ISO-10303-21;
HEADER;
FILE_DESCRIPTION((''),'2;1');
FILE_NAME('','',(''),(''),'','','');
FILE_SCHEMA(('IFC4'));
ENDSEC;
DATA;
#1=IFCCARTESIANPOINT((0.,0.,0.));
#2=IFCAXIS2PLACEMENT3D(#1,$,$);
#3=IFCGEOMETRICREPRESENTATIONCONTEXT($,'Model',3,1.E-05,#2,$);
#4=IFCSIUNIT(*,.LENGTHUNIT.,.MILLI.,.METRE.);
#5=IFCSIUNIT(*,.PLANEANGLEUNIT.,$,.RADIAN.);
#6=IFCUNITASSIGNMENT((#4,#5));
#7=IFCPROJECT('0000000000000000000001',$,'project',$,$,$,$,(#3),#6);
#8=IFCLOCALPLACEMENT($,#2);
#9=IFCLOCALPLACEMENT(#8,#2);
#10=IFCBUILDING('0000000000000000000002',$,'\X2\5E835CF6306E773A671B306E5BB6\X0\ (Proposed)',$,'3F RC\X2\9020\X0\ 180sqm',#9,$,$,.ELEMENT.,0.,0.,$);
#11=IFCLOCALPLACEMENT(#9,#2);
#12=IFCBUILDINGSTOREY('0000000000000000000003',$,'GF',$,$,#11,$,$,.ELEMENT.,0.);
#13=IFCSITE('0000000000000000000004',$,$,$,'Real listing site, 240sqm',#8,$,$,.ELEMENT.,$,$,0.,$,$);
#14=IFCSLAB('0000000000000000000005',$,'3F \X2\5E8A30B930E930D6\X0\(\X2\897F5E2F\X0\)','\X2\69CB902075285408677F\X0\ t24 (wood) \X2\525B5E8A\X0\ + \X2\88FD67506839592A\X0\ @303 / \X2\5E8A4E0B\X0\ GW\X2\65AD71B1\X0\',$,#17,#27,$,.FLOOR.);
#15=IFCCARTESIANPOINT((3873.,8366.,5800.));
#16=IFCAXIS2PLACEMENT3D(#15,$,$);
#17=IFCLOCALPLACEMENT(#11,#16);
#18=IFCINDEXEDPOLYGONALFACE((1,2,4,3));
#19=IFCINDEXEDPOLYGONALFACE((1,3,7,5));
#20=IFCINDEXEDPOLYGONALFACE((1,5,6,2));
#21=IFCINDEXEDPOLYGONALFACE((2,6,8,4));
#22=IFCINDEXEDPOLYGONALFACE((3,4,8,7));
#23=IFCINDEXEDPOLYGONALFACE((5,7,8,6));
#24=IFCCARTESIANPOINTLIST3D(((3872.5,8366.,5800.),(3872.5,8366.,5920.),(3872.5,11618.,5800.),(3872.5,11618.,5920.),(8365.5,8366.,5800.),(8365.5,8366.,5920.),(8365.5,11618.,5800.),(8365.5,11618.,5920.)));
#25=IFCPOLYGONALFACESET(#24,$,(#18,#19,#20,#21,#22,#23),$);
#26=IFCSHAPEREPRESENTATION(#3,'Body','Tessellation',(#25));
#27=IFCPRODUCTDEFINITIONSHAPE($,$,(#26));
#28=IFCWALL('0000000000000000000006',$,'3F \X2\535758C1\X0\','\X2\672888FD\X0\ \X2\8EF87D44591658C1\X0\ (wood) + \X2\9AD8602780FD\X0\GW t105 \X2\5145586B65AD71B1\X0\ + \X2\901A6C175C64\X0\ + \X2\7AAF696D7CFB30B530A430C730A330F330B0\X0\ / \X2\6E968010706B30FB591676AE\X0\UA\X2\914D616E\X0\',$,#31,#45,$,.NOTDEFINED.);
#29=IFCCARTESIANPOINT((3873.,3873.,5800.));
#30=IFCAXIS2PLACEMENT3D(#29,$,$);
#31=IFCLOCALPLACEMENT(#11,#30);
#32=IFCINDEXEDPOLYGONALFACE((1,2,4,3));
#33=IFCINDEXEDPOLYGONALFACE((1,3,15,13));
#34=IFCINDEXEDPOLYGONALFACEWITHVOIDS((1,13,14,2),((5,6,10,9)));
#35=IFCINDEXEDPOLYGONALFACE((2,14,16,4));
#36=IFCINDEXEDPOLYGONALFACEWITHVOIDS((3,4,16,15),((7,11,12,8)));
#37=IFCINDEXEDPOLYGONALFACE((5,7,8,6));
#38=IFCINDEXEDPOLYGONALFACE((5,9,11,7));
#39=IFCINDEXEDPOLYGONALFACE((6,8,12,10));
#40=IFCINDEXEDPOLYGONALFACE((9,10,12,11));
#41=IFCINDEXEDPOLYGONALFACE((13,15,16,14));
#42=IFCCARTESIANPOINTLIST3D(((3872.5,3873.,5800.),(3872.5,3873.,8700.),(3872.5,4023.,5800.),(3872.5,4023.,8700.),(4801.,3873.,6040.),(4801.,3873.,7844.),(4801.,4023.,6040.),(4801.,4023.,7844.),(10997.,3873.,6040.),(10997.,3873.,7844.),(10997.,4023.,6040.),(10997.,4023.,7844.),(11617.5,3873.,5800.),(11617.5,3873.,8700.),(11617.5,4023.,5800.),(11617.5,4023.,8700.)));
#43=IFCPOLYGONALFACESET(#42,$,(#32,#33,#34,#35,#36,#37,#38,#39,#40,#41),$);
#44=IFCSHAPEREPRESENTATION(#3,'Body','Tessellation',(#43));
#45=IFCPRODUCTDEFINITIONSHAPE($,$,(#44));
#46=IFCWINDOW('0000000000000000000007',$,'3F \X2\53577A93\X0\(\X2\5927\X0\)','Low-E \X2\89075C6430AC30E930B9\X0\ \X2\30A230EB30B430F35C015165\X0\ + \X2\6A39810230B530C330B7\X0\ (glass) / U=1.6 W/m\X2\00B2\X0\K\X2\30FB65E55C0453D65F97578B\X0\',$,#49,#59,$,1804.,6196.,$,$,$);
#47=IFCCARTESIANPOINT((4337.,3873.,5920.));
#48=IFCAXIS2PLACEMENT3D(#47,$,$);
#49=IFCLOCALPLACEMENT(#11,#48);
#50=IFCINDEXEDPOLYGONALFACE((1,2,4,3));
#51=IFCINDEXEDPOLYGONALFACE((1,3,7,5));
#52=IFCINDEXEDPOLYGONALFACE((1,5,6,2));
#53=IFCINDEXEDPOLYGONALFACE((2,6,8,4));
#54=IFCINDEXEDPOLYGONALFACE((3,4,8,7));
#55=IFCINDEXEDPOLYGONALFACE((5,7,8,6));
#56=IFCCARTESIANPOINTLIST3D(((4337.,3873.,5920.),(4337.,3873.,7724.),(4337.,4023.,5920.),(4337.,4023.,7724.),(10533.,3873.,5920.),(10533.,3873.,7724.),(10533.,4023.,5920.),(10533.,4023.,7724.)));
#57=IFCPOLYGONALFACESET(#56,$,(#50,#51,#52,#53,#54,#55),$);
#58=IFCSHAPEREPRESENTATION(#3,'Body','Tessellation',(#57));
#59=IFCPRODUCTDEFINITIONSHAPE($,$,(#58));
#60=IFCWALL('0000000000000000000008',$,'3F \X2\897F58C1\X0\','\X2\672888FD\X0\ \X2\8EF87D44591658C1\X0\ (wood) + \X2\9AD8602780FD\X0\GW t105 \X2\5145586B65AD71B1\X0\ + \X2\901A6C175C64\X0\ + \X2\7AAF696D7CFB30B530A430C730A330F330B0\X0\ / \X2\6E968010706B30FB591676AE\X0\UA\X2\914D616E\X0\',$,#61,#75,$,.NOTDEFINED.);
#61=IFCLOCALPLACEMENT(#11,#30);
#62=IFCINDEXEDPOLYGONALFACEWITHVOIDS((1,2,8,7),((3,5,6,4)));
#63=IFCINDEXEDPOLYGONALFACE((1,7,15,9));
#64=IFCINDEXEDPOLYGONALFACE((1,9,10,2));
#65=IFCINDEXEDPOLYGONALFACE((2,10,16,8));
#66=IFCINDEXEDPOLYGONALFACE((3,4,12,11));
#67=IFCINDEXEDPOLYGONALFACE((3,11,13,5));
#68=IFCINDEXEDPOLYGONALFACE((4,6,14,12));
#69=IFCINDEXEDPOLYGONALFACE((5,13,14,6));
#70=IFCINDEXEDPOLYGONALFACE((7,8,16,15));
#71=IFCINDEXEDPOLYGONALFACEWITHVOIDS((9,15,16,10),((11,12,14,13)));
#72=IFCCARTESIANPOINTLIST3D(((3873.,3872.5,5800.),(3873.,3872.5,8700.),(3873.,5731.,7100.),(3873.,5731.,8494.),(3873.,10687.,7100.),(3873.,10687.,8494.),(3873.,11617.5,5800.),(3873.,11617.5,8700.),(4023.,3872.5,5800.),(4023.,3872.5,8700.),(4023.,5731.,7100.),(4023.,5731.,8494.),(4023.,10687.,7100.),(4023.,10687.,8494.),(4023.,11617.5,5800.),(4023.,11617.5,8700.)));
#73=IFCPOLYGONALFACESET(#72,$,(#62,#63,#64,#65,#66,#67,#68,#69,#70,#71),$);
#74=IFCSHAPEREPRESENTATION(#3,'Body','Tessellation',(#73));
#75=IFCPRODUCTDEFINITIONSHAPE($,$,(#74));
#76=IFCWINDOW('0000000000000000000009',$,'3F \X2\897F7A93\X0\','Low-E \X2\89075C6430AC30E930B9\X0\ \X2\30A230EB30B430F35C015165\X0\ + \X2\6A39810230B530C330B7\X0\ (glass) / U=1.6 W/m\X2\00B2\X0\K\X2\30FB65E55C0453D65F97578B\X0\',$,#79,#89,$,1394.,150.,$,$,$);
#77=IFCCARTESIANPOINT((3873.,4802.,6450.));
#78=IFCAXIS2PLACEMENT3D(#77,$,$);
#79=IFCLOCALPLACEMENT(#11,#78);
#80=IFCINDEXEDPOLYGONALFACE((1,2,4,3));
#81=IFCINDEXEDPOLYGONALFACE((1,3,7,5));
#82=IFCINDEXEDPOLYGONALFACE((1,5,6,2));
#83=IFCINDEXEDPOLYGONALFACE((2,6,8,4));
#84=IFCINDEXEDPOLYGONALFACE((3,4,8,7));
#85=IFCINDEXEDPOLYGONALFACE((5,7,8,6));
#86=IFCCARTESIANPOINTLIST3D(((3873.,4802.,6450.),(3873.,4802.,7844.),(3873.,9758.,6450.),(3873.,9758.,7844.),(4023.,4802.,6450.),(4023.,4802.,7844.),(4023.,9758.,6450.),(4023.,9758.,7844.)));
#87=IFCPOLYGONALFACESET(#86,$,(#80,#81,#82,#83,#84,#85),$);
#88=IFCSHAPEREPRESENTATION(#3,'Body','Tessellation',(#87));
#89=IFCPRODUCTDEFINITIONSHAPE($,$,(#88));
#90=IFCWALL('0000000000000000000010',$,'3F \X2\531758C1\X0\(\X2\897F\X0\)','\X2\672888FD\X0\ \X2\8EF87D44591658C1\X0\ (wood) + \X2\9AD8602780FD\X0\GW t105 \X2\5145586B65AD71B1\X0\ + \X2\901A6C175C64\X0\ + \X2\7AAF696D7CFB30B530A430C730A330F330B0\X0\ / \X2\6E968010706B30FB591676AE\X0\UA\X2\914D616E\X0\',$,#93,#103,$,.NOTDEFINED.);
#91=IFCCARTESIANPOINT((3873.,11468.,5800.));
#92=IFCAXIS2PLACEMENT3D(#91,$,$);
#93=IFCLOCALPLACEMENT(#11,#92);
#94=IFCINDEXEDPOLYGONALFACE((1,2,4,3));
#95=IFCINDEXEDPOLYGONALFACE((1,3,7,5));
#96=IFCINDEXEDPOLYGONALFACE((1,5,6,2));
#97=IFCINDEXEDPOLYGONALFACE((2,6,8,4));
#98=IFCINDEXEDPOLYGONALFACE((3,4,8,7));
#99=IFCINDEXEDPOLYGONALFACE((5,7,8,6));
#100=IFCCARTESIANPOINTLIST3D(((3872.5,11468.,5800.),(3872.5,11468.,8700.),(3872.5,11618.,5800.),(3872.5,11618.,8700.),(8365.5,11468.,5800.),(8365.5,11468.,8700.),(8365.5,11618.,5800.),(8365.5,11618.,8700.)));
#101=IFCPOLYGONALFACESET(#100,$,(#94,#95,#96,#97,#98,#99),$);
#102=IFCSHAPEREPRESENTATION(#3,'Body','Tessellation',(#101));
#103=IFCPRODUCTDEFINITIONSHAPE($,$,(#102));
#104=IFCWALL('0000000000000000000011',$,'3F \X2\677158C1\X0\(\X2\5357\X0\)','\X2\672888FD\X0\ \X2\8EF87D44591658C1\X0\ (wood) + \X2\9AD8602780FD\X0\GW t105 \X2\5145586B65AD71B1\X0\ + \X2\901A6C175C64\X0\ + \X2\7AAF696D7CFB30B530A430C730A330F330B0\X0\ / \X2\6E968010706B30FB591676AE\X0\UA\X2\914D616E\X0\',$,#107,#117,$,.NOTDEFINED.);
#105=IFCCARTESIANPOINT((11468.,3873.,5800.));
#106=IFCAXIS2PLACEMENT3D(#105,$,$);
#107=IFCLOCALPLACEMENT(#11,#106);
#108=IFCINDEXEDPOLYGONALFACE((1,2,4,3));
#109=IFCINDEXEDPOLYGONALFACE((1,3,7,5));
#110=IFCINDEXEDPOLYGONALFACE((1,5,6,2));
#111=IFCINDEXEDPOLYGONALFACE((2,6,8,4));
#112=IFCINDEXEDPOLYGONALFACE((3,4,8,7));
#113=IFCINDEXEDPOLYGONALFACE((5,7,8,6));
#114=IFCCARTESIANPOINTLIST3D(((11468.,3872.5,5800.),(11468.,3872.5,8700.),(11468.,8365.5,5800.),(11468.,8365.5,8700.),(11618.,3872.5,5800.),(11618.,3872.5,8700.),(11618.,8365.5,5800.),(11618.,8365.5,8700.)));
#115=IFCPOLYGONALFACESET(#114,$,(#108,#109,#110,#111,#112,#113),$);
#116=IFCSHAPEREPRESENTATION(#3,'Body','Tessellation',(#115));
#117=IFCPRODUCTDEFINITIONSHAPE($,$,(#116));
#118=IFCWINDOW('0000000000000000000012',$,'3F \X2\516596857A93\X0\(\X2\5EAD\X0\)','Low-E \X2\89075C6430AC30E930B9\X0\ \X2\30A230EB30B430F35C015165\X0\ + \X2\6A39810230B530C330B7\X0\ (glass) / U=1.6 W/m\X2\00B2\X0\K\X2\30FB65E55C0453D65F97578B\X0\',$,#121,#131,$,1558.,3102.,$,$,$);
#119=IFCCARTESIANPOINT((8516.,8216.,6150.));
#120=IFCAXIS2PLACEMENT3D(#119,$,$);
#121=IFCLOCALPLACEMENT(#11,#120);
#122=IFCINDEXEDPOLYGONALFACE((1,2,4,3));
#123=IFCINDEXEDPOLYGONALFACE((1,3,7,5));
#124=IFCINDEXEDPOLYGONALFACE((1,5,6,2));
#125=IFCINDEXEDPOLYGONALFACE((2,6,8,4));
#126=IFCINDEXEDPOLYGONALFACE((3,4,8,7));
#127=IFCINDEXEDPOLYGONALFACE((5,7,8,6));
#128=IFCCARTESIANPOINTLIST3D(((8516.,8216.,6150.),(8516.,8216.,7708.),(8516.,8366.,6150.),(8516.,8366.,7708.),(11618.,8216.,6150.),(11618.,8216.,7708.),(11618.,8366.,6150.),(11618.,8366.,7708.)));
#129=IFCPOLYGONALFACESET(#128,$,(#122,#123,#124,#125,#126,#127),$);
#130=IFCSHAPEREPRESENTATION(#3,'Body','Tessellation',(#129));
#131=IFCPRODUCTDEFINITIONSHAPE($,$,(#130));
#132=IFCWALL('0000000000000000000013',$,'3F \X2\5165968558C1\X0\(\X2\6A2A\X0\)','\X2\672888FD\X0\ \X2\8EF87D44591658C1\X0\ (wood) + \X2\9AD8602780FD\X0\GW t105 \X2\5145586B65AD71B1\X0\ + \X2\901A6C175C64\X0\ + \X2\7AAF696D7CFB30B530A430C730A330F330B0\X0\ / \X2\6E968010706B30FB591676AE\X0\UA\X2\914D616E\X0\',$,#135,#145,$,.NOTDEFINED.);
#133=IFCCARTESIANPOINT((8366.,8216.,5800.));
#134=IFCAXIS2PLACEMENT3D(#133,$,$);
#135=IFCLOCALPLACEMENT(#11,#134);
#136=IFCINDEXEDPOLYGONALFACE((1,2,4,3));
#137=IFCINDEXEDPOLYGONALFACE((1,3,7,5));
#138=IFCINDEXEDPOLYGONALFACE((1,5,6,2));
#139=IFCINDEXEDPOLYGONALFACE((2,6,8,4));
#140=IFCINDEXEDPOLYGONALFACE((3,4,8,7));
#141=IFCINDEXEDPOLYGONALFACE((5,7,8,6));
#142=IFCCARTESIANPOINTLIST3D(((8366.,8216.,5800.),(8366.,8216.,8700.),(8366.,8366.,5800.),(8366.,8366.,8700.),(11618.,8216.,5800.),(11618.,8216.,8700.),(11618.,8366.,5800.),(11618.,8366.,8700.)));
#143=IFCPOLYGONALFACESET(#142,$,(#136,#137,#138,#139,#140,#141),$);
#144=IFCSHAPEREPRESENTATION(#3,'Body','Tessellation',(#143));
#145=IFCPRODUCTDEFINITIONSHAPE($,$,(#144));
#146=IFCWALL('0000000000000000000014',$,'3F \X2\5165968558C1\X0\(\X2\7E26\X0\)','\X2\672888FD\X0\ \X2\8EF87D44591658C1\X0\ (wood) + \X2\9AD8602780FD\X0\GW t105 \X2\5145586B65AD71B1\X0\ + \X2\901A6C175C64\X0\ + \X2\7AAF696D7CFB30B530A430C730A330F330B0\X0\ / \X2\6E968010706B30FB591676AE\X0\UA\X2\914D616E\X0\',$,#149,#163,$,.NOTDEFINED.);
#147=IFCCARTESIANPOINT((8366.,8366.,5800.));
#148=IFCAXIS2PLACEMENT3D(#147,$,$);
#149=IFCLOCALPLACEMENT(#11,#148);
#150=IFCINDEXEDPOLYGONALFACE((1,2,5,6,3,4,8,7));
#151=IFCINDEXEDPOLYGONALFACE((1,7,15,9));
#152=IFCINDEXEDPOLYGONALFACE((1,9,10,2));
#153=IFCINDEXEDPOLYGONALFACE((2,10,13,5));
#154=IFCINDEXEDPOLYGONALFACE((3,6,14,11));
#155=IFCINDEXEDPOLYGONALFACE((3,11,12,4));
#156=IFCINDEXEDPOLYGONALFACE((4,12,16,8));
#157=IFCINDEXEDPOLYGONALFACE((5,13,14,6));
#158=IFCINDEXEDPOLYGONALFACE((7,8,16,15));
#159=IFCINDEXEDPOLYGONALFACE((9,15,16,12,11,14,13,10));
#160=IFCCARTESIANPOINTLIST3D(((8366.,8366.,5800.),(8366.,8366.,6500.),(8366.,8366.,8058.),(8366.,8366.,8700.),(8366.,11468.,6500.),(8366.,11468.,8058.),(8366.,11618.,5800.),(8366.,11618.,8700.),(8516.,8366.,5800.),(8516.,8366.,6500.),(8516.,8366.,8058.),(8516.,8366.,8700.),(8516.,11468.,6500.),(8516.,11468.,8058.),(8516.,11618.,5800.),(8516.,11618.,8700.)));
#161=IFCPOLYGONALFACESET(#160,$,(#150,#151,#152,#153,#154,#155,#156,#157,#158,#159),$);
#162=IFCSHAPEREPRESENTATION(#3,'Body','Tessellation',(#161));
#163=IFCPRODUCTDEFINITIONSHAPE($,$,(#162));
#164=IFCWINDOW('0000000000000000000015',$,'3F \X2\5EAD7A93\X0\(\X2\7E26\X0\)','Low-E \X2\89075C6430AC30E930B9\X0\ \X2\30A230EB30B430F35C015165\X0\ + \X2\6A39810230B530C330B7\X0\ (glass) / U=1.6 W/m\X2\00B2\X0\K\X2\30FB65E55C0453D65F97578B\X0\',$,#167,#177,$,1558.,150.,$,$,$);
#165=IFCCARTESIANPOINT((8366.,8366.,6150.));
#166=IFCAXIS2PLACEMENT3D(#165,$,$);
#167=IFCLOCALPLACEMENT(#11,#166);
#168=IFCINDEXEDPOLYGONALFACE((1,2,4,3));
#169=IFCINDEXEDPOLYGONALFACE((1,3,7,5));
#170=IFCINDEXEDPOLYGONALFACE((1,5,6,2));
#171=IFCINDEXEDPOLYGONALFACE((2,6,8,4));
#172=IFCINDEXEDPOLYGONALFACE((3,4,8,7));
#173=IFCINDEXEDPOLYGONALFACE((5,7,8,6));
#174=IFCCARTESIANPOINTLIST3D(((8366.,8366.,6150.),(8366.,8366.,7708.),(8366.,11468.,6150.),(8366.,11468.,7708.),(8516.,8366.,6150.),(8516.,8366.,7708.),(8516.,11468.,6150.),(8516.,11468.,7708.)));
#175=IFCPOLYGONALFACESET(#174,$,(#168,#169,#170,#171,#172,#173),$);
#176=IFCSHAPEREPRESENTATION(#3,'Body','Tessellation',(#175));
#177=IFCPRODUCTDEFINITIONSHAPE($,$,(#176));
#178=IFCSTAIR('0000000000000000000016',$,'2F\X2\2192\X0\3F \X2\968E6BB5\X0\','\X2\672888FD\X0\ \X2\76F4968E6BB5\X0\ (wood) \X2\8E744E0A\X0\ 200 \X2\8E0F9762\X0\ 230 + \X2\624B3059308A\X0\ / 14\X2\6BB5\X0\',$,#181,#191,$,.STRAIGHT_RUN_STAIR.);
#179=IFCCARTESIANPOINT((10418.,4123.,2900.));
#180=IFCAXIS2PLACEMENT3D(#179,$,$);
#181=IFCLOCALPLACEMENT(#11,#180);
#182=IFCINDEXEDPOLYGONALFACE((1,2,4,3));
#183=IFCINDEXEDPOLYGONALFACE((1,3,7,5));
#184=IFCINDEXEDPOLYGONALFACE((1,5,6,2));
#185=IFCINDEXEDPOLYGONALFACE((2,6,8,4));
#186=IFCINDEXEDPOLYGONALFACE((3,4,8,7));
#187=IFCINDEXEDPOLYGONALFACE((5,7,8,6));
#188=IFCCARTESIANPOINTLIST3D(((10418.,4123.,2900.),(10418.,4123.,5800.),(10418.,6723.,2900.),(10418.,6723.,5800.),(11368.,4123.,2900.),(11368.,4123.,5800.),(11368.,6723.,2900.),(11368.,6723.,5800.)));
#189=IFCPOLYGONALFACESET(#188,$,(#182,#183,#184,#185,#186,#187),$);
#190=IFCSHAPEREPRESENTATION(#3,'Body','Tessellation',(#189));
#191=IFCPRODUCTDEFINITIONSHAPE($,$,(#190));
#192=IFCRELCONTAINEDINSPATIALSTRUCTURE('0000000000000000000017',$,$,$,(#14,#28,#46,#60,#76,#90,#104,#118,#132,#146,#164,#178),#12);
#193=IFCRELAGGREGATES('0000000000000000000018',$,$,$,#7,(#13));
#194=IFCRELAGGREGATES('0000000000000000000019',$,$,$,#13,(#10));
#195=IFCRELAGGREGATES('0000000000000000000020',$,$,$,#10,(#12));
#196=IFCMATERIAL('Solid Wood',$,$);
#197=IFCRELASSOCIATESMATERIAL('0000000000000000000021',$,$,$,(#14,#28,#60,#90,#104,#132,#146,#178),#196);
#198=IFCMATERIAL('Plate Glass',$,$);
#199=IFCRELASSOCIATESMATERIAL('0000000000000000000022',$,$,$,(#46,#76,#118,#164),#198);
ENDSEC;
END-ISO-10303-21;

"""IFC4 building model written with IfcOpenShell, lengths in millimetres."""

from ifc_helpers import new_model, si_unit, frame, frame_2d, origin, place, context, project, spatial, rectangle, extrude, material, element, fill, save


model = new_model("IFC4")

# Units and contexts
model_context = context("Model", 3, precision=1e-05, world=origin())
ifc_project = project(units=[si_unit("LENGTHUNIT", "METRE", prefix="MILLI"), si_unit("PLANEANGLEUNIT", "RADIAN")], contexts=[model_context])

# Site, building, storey
site_placement = place(None, origin())
site = spatial("IfcSite", under=ifc_project, at=site_placement, ObjectType="Real listing site, 240sqm", CompositionType="ELEMENT", RefElevation=0.0)
building_placement = place(site_placement, origin())
building = spatial("IfcBuilding", under=site, at=building_placement, Name="広島の眺望の家 (Proposed)", ObjectType="3F RC造 180sqm", CompositionType="ELEMENT", ElevationOfRefHeight=0.0, ElevationOfTerrain=0.0)
storey_placement = place(building_placement, origin())
storey = spatial("IfcBuildingStorey", under=building, at=storey_placement, Name="GF", CompositionType="ELEMENT", Elevation=0.0)

# Slab
ifc_material_1 = material(Name="Solid Wood")
slab_1_placement = place(storey_placement, frame((3873.0, 8366.0, 5800.0)))
element("IfcSlab", 1, at=slab_1_placement, inside=storey, material=ifc_material_1, Name="3F 床スラブ(西帯)", Description="構造用合板 t24 (wood) 剛床 + 製材根太 @303 / 床下 GW断熱", PredefinedType="FLOOR", context=model_context, shape_type="SweptSolid", body=[
    extrude(rectangle(XDim=4493.0, YDim=3252.0, at=frame_2d((2246.0, 1626.0))), frame((3873.0, 8366.0, 5800.0)), (0.0, 0.0, 1.0), 120.0),
])

# Walls, openings, windows
wall_1_placement = place(storey_placement, frame((3873.0, 3873.0, 5800.0)))
wall_1 = element("IfcWall", 2, at=wall_1_placement, inside=storey, material=ifc_material_1, Name="3F 南壁", Description="木製 軸組外壁 (wood) + 高性能GW t105 充填断熱 + 通気層 + 窯業系サイディング / 準耐火・外皮UA配慮", PredefinedType="NOTDEFINED", context=model_context, shape_type="SweptSolid", body=[
    extrude(rectangle(XDim=7745.0, YDim=150.0, at=frame_2d((3872.0, 75.0))), frame((3873.0, 3873.0, 5800.0)), (0.0, 0.0, 1.0), 2900.0),
])
opening_1_placement = place(storey_placement, frame((4337.0, 3873.0, 5920.0)))
opening_1 = element("IfcOpeningElement", 3, at=opening_1_placement, cuts=wall_1, PredefinedType="NOTDEFINED", context=model_context, shape_type="SweptSolid", body=[
    extrude(rectangle(XDim=6196.0, YDim=150.0, at=frame_2d((3098.0, 75.0))), frame((4337.0, 3873.0, 5920.0)), (0.0, 0.0, 1.0), 1804.0),
])
ifc_material_2 = material(Name="Plate Glass")
window_1_placement = place(storey_placement, frame((4337.0, 3873.0, 5920.0)))
window_1 = element("IfcWindow", 4, at=window_1_placement, inside=storey, material=ifc_material_2, Name="3F 南窓(大)", Description="Low-E 複層ガラス アルゴン封入 + 樹脂サッシ (glass) / U=1.6 W/m²K・日射取得型", OverallHeight=1804.0, OverallWidth=6196.0, context=model_context, shape_type="SweptSolid", body=[
    extrude(rectangle(XDim=6196.0, YDim=150.0, at=frame_2d((3098.0, 75.0))), frame((4337.0, 3873.0, 5920.0)), (0.0, 0.0, 1.0), 1804.0),
])
fill(opening_1, window_1)
wall_2_placement = place(storey_placement, frame((3873.0, 3873.0, 5800.0)))
wall_2 = element("IfcWall", 5, at=wall_2_placement, inside=storey, material=ifc_material_1, Name="3F 西壁", Description="木製 軸組外壁 (wood) + 高性能GW t105 充填断熱 + 通気層 + 窯業系サイディング / 準耐火・外皮UA配慮", PredefinedType="NOTDEFINED", context=model_context, shape_type="SweptSolid", body=[
    extrude(rectangle(XDim=150.0, YDim=7745.0, at=frame_2d((75.0, 3872.0))), frame((3873.0, 3873.0, 5800.0)), (0.0, 0.0, 1.0), 2900.0),
])
opening_2_placement = place(storey_placement, frame((3873.0, 4802.0, 6450.0)))
opening_2 = element("IfcOpeningElement", 6, at=opening_2_placement, cuts=wall_2, PredefinedType="NOTDEFINED", context=model_context, shape_type="SweptSolid", body=[
    extrude(rectangle(XDim=150.0, YDim=4956.0, at=frame_2d((75.0, 2478.0))), frame((3873.0, 4802.0, 6450.0)), (0.0, 0.0, 1.0), 1394.0),
])
window_2_placement = place(storey_placement, frame((3873.0, 4802.0, 6450.0)))
window_2 = element("IfcWindow", 7, at=window_2_placement, inside=storey, material=ifc_material_2, Name="3F 西窓", Description="Low-E 複層ガラス アルゴン封入 + 樹脂サッシ (glass) / U=1.6 W/m²K・日射取得型", OverallHeight=1394.0, OverallWidth=150.0, context=model_context, shape_type="SweptSolid", body=[
    extrude(rectangle(XDim=150.0, YDim=4956.0, at=frame_2d((75.0, 2478.0))), frame((3873.0, 4802.0, 6450.0)), (0.0, 0.0, 1.0), 1394.0),
])
fill(opening_2, window_2)

# Wall
wall_3_placement = place(storey_placement, frame((3873.0, 11468.0, 5800.0)))
element("IfcWall", 8, at=wall_3_placement, inside=storey, material=ifc_material_1, Name="3F 北壁(西)", Description="木製 軸組外壁 (wood) + 高性能GW t105 充填断熱 + 通気層 + 窯業系サイディング / 準耐火・外皮UA配慮", PredefinedType="NOTDEFINED", context=model_context, shape_type="SweptSolid", body=[
    extrude(rectangle(XDim=4493.0, YDim=150.0, at=frame_2d((2246.0, 75.0))), frame((3873.0, 11468.0, 5800.0)), (0.0, 0.0, 1.0), 2900.0),
])

# Wall, opening, window
wall_4_placement = place(storey_placement, frame((11468.0, 3873.0, 5800.0)))
wall_4 = element("IfcWall", 9, at=wall_4_placement, inside=storey, material=ifc_material_1, Name="3F 東壁(南)", Description="木製 軸組外壁 (wood) + 高性能GW t105 充填断熱 + 通気層 + 窯業系サイディング / 準耐火・外皮UA配慮", PredefinedType="NOTDEFINED", context=model_context, shape_type="SweptSolid", body=[
    extrude(rectangle(XDim=150.0, YDim=4493.0, at=frame_2d((75.0, 2246.0))), frame((11468.0, 3873.0, 5800.0)), (0.0, 0.0, 1.0), 2900.0),
])
opening_3_placement = place(storey_placement, frame((8516.0, 8216.0, 6150.0)))
opening_3 = element("IfcOpeningElement", 10, at=opening_3_placement, cuts=wall_4, PredefinedType="NOTDEFINED", context=model_context, shape_type="SweptSolid", body=[
    extrude(rectangle(XDim=3102.0, YDim=150.0, at=frame_2d((1551.0, 75.0))), frame((8516.0, 8216.0, 6150.0)), (0.0, 0.0, 1.0), 1558.0),
])
window_3_placement = place(storey_placement, frame((8516.0, 8216.0, 6150.0)))
window_3 = element("IfcWindow", 11, at=window_3_placement, inside=storey, material=ifc_material_2, Name="3F 入隅窓(庭)", Description="Low-E 複層ガラス アルゴン封入 + 樹脂サッシ (glass) / U=1.6 W/m²K・日射取得型", OverallHeight=1558.0, OverallWidth=3102.0, context=model_context, shape_type="SweptSolid", body=[
    extrude(rectangle(XDim=3102.0, YDim=150.0, at=frame_2d((1551.0, 75.0))), frame((8516.0, 8216.0, 6150.0)), (0.0, 0.0, 1.0), 1558.0),
])
fill(opening_3, window_3)

# Wall
wall_5_placement = place(storey_placement, frame((8366.0, 8216.0, 5800.0)))
element("IfcWall", 12, at=wall_5_placement, inside=storey, material=ifc_material_1, Name="3F 入隅壁(横)", Description="木製 軸組外壁 (wood) + 高性能GW t105 充填断熱 + 通気層 + 窯業系サイディング / 準耐火・外皮UA配慮", PredefinedType="NOTDEFINED", context=model_context, shape_type="SweptSolid", body=[
    extrude(rectangle(XDim=3252.0, YDim=150.0, at=frame_2d((1626.0, 75.0))), frame((8366.0, 8216.0, 5800.0)), (0.0, 0.0, 1.0), 2900.0),
])

# Wall, opening, window
wall_6_placement = place(storey_placement, frame((8366.0, 8366.0, 5800.0)))
wall_6 = element("IfcWall", 13, at=wall_6_placement, inside=storey, material=ifc_material_1, Name="3F 入隅壁(縦)", Description="木製 軸組外壁 (wood) + 高性能GW t105 充填断熱 + 通気層 + 窯業系サイディング / 準耐火・外皮UA配慮", PredefinedType="NOTDEFINED", context=model_context, shape_type="SweptSolid", body=[
    extrude(rectangle(XDim=150.0, YDim=3252.0, at=frame_2d((75.0, 1626.0))), frame((8366.0, 8366.0, 5800.0)), (0.0, 0.0, 1.0), 2900.0),
])
opening_4_placement = place(storey_placement, frame((8366.0, 8366.0, 6150.0)))
opening_4 = element("IfcOpeningElement", 14, at=opening_4_placement, cuts=wall_6, PredefinedType="NOTDEFINED", context=model_context, shape_type="SweptSolid", body=[
    extrude(rectangle(XDim=150.0, YDim=3102.0, at=frame_2d((75.0, 1551.0))), frame((8366.0, 8366.0, 6150.0)), (0.0, 0.0, 1.0), 1558.0),
])
window_4_placement = place(storey_placement, frame((8366.0, 8366.0, 6150.0)))
window_4 = element("IfcWindow", 15, at=window_4_placement, inside=storey, material=ifc_material_2, Name="3F 庭窓(縦)", Description="Low-E 複層ガラス アルゴン封入 + 樹脂サッシ (glass) / U=1.6 W/m²K・日射取得型", OverallHeight=1558.0, OverallWidth=150.0, context=model_context, shape_type="SweptSolid", body=[
    extrude(rectangle(XDim=150.0, YDim=3102.0, at=frame_2d((75.0, 1551.0))), frame((8366.0, 8366.0, 6150.0)), (0.0, 0.0, 1.0), 1558.0),
])
fill(opening_4, window_4)

# Stair
stair_placement = place(storey_placement, frame((10418.0, 4123.0, 2900.0)))
element("IfcStair", 16, at=stair_placement, inside=storey, material=ifc_material_1, Name="2F→3F 階段", Description="木製 直階段 (wood) 蹴上 200 踏面 230 + 手すり / 14段", PredefinedType="STRAIGHT_RUN_STAIR", context=model_context, shape_type="SweptSolid", body=[
    extrude(rectangle(XDim=950.0, YDim=2600.0, at=frame_2d((475.0, 1300.0))), frame((10418.0, 4123.0, 2900.0)), (0.0, 0.0, 1.0), 2900.0),
])

save(model, "model.ifc")
